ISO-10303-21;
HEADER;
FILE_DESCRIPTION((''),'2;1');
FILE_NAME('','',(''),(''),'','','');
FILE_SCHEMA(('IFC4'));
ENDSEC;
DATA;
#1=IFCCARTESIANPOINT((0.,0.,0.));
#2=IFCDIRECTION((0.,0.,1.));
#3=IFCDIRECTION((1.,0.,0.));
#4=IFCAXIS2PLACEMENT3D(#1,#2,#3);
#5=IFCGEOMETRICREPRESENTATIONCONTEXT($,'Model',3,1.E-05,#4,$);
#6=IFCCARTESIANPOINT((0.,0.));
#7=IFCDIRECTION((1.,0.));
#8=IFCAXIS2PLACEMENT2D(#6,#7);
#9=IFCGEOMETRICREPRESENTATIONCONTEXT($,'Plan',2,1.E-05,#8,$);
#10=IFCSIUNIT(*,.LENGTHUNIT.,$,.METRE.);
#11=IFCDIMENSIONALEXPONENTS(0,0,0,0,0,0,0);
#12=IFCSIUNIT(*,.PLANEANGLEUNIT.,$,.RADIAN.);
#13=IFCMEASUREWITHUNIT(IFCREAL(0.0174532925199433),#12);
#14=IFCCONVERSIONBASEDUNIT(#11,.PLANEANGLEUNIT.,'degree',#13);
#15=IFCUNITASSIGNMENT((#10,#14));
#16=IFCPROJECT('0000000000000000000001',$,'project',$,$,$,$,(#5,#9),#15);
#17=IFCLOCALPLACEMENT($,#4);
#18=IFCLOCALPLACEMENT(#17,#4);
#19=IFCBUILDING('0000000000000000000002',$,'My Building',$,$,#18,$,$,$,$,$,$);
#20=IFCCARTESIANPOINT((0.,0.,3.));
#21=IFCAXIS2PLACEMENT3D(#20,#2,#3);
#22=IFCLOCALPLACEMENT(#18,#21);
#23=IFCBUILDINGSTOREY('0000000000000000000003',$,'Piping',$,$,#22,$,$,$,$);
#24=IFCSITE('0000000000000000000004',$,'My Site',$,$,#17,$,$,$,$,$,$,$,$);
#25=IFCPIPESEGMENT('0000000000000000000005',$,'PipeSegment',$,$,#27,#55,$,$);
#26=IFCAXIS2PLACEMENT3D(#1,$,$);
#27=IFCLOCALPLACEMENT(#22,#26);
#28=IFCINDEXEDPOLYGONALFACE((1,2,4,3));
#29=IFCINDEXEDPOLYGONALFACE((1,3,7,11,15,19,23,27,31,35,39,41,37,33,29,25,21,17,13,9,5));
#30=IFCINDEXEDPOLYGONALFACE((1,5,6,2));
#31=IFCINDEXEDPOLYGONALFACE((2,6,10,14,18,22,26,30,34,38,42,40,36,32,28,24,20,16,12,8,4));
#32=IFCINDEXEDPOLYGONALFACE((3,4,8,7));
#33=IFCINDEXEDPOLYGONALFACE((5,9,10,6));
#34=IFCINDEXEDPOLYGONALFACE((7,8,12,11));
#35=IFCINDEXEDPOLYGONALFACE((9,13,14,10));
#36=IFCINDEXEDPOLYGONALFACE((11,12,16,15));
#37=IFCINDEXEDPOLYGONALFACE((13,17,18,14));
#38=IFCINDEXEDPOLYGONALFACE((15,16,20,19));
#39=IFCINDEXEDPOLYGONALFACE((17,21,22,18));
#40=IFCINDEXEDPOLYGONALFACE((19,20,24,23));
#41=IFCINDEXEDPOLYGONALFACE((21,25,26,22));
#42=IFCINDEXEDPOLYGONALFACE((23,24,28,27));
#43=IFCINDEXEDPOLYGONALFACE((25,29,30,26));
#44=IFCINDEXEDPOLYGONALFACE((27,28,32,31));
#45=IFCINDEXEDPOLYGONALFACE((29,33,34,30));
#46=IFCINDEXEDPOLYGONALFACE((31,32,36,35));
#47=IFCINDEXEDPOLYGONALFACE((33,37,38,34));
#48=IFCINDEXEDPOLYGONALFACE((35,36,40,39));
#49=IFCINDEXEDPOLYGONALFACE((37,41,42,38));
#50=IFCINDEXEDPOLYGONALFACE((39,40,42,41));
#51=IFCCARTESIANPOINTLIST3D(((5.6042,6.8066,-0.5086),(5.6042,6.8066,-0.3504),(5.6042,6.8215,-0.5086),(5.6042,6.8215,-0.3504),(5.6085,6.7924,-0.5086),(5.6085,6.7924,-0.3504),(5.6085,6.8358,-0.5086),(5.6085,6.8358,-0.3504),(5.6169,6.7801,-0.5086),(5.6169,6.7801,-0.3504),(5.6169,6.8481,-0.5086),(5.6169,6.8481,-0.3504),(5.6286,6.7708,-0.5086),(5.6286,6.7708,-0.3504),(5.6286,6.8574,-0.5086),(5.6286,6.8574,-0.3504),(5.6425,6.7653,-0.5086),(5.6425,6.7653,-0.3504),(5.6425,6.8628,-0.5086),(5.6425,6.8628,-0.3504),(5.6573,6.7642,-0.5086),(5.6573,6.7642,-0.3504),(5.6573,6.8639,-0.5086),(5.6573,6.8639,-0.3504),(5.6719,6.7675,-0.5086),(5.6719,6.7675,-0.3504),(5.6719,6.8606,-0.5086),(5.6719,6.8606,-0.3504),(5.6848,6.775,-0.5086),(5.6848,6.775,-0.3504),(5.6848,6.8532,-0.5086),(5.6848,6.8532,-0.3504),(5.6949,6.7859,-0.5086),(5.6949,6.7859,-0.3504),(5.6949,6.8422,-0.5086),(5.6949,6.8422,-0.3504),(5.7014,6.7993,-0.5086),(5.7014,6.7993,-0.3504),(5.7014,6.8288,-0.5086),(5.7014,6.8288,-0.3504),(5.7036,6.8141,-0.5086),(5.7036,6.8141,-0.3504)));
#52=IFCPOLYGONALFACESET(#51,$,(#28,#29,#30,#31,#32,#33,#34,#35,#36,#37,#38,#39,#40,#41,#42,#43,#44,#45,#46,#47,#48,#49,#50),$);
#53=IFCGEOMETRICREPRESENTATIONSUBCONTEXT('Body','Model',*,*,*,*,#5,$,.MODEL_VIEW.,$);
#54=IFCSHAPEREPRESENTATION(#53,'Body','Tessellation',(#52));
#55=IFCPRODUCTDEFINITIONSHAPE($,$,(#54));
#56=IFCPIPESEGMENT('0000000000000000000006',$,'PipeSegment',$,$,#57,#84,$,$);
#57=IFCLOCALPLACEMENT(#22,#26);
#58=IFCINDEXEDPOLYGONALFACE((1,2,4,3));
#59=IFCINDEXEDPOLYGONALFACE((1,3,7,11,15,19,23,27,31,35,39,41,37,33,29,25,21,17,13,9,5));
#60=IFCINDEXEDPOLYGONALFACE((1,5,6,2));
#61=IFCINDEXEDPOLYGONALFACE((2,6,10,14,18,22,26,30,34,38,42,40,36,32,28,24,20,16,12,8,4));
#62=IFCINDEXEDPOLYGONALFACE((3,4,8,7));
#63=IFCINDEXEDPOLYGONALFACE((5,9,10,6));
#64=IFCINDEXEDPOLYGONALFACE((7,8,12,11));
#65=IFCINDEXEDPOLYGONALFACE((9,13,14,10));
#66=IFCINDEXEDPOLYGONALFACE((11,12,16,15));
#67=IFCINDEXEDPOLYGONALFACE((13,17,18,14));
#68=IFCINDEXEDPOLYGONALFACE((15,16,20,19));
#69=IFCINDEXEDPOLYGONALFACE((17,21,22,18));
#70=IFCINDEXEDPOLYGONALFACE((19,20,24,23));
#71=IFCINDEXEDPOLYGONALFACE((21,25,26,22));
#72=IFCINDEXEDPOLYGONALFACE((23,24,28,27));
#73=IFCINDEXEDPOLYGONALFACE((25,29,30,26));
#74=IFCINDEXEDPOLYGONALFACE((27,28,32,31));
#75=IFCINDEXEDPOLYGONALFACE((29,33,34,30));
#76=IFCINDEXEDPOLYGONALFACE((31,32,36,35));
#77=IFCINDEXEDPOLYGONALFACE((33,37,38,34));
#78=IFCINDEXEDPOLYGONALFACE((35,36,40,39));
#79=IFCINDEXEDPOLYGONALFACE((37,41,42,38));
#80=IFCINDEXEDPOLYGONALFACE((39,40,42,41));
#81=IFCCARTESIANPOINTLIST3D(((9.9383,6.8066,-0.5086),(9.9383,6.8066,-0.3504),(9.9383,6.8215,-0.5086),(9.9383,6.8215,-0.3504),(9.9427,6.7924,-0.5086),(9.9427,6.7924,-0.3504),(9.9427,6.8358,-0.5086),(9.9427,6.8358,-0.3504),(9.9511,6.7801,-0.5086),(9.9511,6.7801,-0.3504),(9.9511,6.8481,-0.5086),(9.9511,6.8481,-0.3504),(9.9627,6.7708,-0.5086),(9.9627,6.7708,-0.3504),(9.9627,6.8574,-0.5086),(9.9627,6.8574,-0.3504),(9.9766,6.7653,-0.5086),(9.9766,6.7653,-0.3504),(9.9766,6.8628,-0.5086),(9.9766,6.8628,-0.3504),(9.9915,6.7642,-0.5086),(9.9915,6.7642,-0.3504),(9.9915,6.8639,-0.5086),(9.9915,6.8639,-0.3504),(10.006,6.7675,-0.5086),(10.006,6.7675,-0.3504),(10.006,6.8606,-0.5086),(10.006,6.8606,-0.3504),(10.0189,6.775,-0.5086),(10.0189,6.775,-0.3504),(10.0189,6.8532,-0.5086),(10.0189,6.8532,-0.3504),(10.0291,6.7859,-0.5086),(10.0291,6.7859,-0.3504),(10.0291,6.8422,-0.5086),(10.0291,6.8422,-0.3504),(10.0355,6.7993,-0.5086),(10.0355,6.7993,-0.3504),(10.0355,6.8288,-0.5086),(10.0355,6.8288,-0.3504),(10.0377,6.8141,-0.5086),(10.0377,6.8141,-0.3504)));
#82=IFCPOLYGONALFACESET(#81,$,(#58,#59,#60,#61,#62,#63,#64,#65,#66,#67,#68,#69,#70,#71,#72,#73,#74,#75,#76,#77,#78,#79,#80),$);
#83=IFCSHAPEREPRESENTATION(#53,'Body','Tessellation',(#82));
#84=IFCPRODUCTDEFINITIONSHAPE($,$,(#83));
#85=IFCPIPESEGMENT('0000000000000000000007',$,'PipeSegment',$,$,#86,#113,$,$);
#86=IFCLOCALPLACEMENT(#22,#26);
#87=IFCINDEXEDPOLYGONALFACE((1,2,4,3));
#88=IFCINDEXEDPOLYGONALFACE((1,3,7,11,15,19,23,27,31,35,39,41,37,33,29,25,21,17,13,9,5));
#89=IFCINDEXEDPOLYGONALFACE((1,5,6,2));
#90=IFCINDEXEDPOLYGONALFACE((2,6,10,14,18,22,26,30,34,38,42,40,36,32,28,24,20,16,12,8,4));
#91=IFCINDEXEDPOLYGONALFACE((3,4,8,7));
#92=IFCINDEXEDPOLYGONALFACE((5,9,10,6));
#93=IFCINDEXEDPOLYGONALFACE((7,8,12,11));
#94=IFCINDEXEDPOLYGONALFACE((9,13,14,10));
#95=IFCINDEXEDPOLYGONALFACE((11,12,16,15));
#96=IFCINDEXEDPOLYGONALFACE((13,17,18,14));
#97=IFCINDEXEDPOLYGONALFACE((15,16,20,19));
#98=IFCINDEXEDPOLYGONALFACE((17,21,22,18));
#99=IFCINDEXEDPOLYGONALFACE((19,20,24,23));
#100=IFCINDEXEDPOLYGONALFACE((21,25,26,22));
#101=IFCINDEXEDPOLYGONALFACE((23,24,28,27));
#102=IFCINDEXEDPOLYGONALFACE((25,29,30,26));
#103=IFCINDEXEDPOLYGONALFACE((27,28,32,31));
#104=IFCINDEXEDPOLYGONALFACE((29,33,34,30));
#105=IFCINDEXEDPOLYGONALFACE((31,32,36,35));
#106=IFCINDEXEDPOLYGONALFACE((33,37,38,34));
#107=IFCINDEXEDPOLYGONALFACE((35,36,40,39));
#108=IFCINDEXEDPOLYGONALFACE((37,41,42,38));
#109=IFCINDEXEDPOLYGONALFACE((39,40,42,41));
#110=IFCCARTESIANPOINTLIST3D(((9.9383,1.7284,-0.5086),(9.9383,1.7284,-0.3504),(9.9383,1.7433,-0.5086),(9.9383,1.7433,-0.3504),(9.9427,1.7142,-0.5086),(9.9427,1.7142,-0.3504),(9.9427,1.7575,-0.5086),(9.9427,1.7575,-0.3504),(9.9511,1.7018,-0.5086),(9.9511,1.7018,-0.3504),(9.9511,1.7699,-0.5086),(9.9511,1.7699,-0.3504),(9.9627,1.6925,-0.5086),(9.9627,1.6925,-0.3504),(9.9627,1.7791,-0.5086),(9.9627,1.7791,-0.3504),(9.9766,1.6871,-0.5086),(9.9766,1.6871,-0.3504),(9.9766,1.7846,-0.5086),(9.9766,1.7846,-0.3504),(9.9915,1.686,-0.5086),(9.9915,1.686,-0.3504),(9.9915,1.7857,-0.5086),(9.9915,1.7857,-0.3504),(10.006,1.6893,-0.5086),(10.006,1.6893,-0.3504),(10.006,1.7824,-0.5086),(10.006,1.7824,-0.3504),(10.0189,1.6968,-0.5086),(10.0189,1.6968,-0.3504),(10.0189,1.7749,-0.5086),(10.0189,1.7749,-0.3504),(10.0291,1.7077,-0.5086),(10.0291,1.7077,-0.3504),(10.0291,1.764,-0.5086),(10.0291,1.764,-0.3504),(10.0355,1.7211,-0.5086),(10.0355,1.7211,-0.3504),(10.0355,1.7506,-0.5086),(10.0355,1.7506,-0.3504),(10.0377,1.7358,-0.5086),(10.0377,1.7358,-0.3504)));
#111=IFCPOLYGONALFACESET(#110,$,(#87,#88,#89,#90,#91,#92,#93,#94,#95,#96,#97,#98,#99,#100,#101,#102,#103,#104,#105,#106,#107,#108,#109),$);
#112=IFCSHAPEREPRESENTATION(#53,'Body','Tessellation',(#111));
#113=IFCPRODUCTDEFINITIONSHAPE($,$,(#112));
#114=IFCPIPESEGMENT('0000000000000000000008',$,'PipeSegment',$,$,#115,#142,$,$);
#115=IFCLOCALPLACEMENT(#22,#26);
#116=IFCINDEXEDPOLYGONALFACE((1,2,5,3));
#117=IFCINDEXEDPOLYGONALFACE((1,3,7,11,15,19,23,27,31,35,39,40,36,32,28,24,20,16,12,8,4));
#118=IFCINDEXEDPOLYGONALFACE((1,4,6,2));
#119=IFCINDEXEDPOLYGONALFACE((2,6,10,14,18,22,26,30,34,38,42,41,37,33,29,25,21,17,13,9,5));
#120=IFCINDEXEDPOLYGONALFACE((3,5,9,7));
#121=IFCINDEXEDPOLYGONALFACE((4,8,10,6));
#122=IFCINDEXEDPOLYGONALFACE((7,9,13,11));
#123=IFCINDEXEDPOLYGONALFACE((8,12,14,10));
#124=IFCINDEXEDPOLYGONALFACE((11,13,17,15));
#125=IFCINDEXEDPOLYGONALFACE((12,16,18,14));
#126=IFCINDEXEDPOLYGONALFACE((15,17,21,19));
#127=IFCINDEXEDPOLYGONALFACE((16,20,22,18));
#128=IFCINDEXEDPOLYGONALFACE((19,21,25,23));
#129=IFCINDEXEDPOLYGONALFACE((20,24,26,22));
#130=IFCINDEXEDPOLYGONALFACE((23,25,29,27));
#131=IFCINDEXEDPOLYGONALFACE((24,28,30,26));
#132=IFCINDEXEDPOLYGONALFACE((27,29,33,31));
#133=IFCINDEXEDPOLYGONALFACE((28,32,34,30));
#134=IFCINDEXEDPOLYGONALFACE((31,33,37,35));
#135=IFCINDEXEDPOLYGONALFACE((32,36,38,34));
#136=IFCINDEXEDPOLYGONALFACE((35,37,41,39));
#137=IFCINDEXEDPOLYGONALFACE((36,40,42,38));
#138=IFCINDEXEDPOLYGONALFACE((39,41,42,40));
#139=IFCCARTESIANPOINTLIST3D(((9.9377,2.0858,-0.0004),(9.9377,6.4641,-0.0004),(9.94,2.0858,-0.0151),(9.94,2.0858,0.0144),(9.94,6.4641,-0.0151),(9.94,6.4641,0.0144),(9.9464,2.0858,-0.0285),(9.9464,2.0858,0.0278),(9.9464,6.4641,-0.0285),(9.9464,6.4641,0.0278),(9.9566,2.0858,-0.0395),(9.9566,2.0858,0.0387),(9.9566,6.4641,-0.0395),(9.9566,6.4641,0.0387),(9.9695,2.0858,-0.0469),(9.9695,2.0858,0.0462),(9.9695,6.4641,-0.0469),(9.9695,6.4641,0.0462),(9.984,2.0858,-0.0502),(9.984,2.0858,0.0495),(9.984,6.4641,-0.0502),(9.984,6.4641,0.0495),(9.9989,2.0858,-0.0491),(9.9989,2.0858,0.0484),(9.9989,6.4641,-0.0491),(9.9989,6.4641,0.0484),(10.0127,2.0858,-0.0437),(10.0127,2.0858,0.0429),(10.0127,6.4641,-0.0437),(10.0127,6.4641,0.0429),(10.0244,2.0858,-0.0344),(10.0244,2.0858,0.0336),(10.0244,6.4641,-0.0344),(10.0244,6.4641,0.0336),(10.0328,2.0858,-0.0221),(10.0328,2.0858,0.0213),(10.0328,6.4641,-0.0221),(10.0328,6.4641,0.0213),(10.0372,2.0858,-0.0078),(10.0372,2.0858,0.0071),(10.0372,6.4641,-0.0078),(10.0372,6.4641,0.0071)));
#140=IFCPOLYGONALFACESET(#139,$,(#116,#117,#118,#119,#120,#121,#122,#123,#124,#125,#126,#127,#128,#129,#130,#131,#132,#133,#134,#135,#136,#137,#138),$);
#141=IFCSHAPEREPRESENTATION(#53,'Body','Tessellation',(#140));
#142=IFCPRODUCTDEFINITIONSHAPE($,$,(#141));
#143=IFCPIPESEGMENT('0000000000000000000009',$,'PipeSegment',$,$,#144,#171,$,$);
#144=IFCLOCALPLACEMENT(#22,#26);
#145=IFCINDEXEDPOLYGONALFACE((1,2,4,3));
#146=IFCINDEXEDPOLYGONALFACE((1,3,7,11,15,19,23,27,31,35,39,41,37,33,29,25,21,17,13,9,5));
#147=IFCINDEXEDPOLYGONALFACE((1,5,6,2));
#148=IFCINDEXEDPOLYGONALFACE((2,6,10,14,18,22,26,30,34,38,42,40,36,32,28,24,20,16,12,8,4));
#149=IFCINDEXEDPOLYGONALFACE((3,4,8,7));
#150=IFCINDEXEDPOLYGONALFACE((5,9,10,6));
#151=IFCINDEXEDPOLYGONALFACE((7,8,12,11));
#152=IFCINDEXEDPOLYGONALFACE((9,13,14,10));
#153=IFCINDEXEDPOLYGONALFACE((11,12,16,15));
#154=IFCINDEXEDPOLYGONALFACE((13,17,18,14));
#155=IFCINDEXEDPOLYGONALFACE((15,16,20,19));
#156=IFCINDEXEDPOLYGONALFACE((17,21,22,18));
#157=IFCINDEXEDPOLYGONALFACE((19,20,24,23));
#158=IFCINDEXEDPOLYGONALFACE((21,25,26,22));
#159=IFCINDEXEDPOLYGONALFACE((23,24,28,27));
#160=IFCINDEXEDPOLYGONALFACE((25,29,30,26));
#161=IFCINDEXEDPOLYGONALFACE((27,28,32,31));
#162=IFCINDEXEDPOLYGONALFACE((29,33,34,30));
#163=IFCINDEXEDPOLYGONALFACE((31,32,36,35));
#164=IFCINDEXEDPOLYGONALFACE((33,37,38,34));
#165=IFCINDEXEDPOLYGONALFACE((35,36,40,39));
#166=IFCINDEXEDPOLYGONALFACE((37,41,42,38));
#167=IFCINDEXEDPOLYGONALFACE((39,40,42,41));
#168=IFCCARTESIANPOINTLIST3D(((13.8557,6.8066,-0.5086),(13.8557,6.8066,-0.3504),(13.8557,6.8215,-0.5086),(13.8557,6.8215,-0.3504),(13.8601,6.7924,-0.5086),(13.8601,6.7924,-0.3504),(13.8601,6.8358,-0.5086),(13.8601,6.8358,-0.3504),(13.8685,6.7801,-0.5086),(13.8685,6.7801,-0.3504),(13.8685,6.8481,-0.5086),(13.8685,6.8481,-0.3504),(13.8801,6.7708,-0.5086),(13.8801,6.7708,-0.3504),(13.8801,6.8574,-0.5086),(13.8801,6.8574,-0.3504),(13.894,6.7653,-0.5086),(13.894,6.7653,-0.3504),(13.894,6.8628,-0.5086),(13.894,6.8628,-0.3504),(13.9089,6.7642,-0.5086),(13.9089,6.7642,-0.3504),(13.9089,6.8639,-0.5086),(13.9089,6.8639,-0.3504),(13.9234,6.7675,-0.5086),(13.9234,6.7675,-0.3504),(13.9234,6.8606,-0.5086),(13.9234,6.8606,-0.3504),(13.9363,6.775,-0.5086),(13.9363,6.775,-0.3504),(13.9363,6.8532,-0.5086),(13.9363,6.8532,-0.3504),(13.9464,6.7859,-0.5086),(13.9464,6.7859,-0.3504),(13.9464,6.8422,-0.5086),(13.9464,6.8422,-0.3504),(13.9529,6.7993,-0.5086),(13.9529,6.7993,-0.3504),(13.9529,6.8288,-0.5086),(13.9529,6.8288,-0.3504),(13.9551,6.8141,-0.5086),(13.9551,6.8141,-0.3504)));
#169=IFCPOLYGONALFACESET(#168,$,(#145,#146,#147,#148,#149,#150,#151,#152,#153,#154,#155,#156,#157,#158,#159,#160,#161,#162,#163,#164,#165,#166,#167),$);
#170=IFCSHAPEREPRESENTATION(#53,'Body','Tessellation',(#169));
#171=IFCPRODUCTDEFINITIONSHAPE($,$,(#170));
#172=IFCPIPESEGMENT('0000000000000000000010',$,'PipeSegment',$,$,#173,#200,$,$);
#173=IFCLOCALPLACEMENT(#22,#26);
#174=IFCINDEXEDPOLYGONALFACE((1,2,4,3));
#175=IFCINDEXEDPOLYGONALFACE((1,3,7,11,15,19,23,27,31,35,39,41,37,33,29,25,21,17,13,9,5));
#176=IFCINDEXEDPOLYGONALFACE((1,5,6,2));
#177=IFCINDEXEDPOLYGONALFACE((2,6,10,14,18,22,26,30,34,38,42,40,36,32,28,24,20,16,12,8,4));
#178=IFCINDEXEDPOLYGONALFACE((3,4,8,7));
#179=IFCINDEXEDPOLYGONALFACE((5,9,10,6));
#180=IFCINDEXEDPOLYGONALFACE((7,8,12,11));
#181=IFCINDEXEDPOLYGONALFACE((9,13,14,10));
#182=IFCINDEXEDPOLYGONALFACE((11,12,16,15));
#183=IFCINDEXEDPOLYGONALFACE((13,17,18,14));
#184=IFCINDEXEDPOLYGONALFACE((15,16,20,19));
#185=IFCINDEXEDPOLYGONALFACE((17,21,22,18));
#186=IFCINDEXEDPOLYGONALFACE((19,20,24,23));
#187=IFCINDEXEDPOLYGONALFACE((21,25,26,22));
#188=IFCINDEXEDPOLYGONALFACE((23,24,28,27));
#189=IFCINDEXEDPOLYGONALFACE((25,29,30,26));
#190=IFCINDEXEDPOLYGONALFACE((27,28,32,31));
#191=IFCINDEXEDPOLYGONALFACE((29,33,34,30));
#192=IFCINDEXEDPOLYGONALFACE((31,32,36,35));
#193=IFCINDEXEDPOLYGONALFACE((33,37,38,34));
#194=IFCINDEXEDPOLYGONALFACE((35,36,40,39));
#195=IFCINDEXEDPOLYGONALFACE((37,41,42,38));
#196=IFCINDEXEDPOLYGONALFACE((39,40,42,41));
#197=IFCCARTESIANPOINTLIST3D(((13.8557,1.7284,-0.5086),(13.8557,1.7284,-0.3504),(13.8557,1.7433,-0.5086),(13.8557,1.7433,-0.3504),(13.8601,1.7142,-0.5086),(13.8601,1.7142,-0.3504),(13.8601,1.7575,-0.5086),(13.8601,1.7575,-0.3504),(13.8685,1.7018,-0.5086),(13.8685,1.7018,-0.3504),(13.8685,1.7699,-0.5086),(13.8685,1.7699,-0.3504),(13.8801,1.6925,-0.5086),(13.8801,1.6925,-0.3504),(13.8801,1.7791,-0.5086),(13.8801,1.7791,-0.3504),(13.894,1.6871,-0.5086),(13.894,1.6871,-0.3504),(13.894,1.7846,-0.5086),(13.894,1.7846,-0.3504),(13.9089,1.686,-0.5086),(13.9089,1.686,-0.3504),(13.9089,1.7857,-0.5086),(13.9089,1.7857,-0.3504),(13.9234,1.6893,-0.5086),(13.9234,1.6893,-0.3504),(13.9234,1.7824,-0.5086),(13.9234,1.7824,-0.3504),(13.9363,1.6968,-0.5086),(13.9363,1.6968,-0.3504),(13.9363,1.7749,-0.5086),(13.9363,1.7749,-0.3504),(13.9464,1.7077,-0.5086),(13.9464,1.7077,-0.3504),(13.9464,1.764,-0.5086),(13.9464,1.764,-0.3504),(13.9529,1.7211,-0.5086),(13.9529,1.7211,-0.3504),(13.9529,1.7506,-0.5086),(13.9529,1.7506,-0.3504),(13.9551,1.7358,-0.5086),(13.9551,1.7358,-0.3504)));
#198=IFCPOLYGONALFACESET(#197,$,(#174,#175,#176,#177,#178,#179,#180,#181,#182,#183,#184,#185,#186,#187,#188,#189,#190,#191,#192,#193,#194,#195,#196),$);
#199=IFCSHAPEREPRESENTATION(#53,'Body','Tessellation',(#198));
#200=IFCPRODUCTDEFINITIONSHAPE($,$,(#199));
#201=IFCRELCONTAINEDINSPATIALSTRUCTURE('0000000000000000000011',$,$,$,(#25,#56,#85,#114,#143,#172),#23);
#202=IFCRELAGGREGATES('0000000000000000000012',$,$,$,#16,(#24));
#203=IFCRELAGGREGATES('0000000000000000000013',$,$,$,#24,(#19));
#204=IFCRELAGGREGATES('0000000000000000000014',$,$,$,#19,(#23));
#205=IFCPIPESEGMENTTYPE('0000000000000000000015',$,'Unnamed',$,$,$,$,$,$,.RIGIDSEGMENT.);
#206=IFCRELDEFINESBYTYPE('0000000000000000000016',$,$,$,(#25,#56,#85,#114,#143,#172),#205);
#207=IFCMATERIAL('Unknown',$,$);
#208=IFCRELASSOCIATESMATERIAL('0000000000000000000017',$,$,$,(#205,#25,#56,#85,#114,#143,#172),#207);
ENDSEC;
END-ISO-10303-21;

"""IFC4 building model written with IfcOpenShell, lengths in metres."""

from ifc_helpers import new_model, entity, si_unit, converted_unit, frame, origin_with_axes, origin_2d_with_axis, place, context, subcontext, project, spatial, circle, extrude, material, material_profile, profile_set, profile_usage, type_object, element, save


model = new_model("IFC4")

# Units and contexts
model_context = context("Model", 3, precision=1e-05, world=origin_with_axes())
plan_context = context("Plan", 2, precision=1e-05, world=origin_2d_with_axis())
body_context = subcontext(model_context, "Body", "Model", "MODEL_VIEW")
ifc_project = project(units=[si_unit("LENGTHUNIT", "METRE"), converted_unit("PLANEANGLEUNIT", "degree", entity("IfcReal", 0.0174532925199433), si_unit("PLANEANGLEUNIT", "RADIAN"), dimensions=[0, 0, 0, 0, 0, 0, 0])], contexts=[model_context, plan_context])

# Site, building, storey
site_placement = place(None, origin_with_axes())
site = spatial("IfcSite", under=ifc_project, at=site_placement, Name="My Site")
building_placement = place(site_placement, origin_with_axes())
building = spatial("IfcBuilding", under=site, at=building_placement, Name="My Building")
storey_placement = place(building_placement, frame((0.0, 0.0, 3.0), z_axis=(0.0, 0.0, 1.0), x_axis=(1.0, 0.0, 0.0)))
storey = spatial("IfcBuildingStorey", under=building, at=storey_placement, Name="Piping")

# Pipe segments
ifc_material = material(Name="Unknown")
ifc_material_profile = material_profile(ifc_material, circle(Radius=0.05))
ifc_profile_set = profile_set([ifc_material_profile])
pipe_segment_type = type_object("IfcPipeSegmentType", Name="Unnamed", PredefinedType="RIGIDSEGMENT", material=ifc_profile_set)
ifc_profile_usage_1 = profile_usage(ifc_profile_set, cardinal=5)
pipe_segment_1_placement = place(storey_placement, frame((5.6536, 6.8141, -0.3504), z_axis=(0.0, 0.0, -1.0), x_axis=(1.0, 0.0, 0.0)))
element("IfcPipeSegment", 1, at=pipe_segment_1_placement, inside=storey, type_object=pipe_segment_type, material=ifc_profile_usage_1, Name="PipeSegment", context=body_context, shape_type="SweptSolid", body=[
    extrude(circle(Radius=0.05), origin_with_axes(), (0.0, 0.0, 1.0), 0.1582),
])
ifc_profile_usage_2 = profile_usage(ifc_profile_set, cardinal=5)
pipe_segment_2_placement = place(storey_placement, frame((9.9877, 6.8141, -0.3504), z_axis=(0.0, 0.0, -1.0), x_axis=(1.0, 0.0, 0.0)))
element("IfcPipeSegment", 2, at=pipe_segment_2_placement, inside=storey, type_object=pipe_segment_type, material=ifc_profile_usage_2, Name="PipeSegment", context=body_context, shape_type="SweptSolid", body=[
    extrude(circle(Radius=0.05), origin_with_axes(), (0.0, 0.0, 1.0), 0.1582),
])
ifc_profile_usage_3 = profile_usage(ifc_profile_set, cardinal=5)
pipe_segment_3_placement = place(storey_placement, frame((9.9877, 1.7358, -0.3504), z_axis=(0.0, 0.0, -1.0), x_axis=(1.0, 0.0, 0.0)))
element("IfcPipeSegment", 3, at=pipe_segment_3_placement, inside=storey, type_object=pipe_segment_type, material=ifc_profile_usage_3, Name="PipeSegment", context=body_context, shape_type="SweptSolid", body=[
    extrude(circle(Radius=0.05), origin_with_axes(), (0.0, 0.0, 1.0), 0.1582),
])
ifc_profile_usage_4 = profile_usage(ifc_profile_set, cardinal=5)
pipe_segment_4_placement = place(storey_placement, frame((9.9877, 2.0858, -0.0004), z_axis=(0.0, 1.0, 0.0), x_axis=(-1.0, 0.0, 0.0)))
element("IfcPipeSegment", 4, at=pipe_segment_4_placement, inside=storey, type_object=pipe_segment_type, material=ifc_profile_usage_4, Name="PipeSegment", context=body_context, shape_type="SweptSolid", body=[
    extrude(circle(Radius=0.05), origin_with_axes(), (0.0, 0.0, 1.0), 4.3782),
])
ifc_profile_usage_5 = profile_usage(ifc_profile_set, cardinal=5)
pipe_segment_5_placement = place(storey_placement, frame((13.9051, 6.8141, -0.3504), z_axis=(0.0, 0.0, -1.0), x_axis=(1.0, 0.0, 0.0)))
element("IfcPipeSegment", 5, at=pipe_segment_5_placement, inside=storey, type_object=pipe_segment_type, material=ifc_profile_usage_5, Name="PipeSegment", context=body_context, shape_type="SweptSolid", body=[
    extrude(circle(Radius=0.05), origin_with_axes(), (0.0, 0.0, 1.0), 0.1582),
])
ifc_profile_usage_6 = profile_usage(ifc_profile_set, cardinal=5)
pipe_segment_6_placement = place(storey_placement, frame((13.9051, 1.7358, -0.3504), z_axis=(0.0, 0.0, -1.0), x_axis=(1.0, 0.0, 0.0)))
element("IfcPipeSegment", 6, at=pipe_segment_6_placement, inside=storey, type_object=pipe_segment_type, material=ifc_profile_usage_6, Name="PipeSegment", context=body_context, shape_type="SweptSolid", body=[
    extrude(circle(Radius=0.05), origin_with_axes(), (0.0, 0.0, 1.0), 0.1582),
])

save(model, "model.ifc")
